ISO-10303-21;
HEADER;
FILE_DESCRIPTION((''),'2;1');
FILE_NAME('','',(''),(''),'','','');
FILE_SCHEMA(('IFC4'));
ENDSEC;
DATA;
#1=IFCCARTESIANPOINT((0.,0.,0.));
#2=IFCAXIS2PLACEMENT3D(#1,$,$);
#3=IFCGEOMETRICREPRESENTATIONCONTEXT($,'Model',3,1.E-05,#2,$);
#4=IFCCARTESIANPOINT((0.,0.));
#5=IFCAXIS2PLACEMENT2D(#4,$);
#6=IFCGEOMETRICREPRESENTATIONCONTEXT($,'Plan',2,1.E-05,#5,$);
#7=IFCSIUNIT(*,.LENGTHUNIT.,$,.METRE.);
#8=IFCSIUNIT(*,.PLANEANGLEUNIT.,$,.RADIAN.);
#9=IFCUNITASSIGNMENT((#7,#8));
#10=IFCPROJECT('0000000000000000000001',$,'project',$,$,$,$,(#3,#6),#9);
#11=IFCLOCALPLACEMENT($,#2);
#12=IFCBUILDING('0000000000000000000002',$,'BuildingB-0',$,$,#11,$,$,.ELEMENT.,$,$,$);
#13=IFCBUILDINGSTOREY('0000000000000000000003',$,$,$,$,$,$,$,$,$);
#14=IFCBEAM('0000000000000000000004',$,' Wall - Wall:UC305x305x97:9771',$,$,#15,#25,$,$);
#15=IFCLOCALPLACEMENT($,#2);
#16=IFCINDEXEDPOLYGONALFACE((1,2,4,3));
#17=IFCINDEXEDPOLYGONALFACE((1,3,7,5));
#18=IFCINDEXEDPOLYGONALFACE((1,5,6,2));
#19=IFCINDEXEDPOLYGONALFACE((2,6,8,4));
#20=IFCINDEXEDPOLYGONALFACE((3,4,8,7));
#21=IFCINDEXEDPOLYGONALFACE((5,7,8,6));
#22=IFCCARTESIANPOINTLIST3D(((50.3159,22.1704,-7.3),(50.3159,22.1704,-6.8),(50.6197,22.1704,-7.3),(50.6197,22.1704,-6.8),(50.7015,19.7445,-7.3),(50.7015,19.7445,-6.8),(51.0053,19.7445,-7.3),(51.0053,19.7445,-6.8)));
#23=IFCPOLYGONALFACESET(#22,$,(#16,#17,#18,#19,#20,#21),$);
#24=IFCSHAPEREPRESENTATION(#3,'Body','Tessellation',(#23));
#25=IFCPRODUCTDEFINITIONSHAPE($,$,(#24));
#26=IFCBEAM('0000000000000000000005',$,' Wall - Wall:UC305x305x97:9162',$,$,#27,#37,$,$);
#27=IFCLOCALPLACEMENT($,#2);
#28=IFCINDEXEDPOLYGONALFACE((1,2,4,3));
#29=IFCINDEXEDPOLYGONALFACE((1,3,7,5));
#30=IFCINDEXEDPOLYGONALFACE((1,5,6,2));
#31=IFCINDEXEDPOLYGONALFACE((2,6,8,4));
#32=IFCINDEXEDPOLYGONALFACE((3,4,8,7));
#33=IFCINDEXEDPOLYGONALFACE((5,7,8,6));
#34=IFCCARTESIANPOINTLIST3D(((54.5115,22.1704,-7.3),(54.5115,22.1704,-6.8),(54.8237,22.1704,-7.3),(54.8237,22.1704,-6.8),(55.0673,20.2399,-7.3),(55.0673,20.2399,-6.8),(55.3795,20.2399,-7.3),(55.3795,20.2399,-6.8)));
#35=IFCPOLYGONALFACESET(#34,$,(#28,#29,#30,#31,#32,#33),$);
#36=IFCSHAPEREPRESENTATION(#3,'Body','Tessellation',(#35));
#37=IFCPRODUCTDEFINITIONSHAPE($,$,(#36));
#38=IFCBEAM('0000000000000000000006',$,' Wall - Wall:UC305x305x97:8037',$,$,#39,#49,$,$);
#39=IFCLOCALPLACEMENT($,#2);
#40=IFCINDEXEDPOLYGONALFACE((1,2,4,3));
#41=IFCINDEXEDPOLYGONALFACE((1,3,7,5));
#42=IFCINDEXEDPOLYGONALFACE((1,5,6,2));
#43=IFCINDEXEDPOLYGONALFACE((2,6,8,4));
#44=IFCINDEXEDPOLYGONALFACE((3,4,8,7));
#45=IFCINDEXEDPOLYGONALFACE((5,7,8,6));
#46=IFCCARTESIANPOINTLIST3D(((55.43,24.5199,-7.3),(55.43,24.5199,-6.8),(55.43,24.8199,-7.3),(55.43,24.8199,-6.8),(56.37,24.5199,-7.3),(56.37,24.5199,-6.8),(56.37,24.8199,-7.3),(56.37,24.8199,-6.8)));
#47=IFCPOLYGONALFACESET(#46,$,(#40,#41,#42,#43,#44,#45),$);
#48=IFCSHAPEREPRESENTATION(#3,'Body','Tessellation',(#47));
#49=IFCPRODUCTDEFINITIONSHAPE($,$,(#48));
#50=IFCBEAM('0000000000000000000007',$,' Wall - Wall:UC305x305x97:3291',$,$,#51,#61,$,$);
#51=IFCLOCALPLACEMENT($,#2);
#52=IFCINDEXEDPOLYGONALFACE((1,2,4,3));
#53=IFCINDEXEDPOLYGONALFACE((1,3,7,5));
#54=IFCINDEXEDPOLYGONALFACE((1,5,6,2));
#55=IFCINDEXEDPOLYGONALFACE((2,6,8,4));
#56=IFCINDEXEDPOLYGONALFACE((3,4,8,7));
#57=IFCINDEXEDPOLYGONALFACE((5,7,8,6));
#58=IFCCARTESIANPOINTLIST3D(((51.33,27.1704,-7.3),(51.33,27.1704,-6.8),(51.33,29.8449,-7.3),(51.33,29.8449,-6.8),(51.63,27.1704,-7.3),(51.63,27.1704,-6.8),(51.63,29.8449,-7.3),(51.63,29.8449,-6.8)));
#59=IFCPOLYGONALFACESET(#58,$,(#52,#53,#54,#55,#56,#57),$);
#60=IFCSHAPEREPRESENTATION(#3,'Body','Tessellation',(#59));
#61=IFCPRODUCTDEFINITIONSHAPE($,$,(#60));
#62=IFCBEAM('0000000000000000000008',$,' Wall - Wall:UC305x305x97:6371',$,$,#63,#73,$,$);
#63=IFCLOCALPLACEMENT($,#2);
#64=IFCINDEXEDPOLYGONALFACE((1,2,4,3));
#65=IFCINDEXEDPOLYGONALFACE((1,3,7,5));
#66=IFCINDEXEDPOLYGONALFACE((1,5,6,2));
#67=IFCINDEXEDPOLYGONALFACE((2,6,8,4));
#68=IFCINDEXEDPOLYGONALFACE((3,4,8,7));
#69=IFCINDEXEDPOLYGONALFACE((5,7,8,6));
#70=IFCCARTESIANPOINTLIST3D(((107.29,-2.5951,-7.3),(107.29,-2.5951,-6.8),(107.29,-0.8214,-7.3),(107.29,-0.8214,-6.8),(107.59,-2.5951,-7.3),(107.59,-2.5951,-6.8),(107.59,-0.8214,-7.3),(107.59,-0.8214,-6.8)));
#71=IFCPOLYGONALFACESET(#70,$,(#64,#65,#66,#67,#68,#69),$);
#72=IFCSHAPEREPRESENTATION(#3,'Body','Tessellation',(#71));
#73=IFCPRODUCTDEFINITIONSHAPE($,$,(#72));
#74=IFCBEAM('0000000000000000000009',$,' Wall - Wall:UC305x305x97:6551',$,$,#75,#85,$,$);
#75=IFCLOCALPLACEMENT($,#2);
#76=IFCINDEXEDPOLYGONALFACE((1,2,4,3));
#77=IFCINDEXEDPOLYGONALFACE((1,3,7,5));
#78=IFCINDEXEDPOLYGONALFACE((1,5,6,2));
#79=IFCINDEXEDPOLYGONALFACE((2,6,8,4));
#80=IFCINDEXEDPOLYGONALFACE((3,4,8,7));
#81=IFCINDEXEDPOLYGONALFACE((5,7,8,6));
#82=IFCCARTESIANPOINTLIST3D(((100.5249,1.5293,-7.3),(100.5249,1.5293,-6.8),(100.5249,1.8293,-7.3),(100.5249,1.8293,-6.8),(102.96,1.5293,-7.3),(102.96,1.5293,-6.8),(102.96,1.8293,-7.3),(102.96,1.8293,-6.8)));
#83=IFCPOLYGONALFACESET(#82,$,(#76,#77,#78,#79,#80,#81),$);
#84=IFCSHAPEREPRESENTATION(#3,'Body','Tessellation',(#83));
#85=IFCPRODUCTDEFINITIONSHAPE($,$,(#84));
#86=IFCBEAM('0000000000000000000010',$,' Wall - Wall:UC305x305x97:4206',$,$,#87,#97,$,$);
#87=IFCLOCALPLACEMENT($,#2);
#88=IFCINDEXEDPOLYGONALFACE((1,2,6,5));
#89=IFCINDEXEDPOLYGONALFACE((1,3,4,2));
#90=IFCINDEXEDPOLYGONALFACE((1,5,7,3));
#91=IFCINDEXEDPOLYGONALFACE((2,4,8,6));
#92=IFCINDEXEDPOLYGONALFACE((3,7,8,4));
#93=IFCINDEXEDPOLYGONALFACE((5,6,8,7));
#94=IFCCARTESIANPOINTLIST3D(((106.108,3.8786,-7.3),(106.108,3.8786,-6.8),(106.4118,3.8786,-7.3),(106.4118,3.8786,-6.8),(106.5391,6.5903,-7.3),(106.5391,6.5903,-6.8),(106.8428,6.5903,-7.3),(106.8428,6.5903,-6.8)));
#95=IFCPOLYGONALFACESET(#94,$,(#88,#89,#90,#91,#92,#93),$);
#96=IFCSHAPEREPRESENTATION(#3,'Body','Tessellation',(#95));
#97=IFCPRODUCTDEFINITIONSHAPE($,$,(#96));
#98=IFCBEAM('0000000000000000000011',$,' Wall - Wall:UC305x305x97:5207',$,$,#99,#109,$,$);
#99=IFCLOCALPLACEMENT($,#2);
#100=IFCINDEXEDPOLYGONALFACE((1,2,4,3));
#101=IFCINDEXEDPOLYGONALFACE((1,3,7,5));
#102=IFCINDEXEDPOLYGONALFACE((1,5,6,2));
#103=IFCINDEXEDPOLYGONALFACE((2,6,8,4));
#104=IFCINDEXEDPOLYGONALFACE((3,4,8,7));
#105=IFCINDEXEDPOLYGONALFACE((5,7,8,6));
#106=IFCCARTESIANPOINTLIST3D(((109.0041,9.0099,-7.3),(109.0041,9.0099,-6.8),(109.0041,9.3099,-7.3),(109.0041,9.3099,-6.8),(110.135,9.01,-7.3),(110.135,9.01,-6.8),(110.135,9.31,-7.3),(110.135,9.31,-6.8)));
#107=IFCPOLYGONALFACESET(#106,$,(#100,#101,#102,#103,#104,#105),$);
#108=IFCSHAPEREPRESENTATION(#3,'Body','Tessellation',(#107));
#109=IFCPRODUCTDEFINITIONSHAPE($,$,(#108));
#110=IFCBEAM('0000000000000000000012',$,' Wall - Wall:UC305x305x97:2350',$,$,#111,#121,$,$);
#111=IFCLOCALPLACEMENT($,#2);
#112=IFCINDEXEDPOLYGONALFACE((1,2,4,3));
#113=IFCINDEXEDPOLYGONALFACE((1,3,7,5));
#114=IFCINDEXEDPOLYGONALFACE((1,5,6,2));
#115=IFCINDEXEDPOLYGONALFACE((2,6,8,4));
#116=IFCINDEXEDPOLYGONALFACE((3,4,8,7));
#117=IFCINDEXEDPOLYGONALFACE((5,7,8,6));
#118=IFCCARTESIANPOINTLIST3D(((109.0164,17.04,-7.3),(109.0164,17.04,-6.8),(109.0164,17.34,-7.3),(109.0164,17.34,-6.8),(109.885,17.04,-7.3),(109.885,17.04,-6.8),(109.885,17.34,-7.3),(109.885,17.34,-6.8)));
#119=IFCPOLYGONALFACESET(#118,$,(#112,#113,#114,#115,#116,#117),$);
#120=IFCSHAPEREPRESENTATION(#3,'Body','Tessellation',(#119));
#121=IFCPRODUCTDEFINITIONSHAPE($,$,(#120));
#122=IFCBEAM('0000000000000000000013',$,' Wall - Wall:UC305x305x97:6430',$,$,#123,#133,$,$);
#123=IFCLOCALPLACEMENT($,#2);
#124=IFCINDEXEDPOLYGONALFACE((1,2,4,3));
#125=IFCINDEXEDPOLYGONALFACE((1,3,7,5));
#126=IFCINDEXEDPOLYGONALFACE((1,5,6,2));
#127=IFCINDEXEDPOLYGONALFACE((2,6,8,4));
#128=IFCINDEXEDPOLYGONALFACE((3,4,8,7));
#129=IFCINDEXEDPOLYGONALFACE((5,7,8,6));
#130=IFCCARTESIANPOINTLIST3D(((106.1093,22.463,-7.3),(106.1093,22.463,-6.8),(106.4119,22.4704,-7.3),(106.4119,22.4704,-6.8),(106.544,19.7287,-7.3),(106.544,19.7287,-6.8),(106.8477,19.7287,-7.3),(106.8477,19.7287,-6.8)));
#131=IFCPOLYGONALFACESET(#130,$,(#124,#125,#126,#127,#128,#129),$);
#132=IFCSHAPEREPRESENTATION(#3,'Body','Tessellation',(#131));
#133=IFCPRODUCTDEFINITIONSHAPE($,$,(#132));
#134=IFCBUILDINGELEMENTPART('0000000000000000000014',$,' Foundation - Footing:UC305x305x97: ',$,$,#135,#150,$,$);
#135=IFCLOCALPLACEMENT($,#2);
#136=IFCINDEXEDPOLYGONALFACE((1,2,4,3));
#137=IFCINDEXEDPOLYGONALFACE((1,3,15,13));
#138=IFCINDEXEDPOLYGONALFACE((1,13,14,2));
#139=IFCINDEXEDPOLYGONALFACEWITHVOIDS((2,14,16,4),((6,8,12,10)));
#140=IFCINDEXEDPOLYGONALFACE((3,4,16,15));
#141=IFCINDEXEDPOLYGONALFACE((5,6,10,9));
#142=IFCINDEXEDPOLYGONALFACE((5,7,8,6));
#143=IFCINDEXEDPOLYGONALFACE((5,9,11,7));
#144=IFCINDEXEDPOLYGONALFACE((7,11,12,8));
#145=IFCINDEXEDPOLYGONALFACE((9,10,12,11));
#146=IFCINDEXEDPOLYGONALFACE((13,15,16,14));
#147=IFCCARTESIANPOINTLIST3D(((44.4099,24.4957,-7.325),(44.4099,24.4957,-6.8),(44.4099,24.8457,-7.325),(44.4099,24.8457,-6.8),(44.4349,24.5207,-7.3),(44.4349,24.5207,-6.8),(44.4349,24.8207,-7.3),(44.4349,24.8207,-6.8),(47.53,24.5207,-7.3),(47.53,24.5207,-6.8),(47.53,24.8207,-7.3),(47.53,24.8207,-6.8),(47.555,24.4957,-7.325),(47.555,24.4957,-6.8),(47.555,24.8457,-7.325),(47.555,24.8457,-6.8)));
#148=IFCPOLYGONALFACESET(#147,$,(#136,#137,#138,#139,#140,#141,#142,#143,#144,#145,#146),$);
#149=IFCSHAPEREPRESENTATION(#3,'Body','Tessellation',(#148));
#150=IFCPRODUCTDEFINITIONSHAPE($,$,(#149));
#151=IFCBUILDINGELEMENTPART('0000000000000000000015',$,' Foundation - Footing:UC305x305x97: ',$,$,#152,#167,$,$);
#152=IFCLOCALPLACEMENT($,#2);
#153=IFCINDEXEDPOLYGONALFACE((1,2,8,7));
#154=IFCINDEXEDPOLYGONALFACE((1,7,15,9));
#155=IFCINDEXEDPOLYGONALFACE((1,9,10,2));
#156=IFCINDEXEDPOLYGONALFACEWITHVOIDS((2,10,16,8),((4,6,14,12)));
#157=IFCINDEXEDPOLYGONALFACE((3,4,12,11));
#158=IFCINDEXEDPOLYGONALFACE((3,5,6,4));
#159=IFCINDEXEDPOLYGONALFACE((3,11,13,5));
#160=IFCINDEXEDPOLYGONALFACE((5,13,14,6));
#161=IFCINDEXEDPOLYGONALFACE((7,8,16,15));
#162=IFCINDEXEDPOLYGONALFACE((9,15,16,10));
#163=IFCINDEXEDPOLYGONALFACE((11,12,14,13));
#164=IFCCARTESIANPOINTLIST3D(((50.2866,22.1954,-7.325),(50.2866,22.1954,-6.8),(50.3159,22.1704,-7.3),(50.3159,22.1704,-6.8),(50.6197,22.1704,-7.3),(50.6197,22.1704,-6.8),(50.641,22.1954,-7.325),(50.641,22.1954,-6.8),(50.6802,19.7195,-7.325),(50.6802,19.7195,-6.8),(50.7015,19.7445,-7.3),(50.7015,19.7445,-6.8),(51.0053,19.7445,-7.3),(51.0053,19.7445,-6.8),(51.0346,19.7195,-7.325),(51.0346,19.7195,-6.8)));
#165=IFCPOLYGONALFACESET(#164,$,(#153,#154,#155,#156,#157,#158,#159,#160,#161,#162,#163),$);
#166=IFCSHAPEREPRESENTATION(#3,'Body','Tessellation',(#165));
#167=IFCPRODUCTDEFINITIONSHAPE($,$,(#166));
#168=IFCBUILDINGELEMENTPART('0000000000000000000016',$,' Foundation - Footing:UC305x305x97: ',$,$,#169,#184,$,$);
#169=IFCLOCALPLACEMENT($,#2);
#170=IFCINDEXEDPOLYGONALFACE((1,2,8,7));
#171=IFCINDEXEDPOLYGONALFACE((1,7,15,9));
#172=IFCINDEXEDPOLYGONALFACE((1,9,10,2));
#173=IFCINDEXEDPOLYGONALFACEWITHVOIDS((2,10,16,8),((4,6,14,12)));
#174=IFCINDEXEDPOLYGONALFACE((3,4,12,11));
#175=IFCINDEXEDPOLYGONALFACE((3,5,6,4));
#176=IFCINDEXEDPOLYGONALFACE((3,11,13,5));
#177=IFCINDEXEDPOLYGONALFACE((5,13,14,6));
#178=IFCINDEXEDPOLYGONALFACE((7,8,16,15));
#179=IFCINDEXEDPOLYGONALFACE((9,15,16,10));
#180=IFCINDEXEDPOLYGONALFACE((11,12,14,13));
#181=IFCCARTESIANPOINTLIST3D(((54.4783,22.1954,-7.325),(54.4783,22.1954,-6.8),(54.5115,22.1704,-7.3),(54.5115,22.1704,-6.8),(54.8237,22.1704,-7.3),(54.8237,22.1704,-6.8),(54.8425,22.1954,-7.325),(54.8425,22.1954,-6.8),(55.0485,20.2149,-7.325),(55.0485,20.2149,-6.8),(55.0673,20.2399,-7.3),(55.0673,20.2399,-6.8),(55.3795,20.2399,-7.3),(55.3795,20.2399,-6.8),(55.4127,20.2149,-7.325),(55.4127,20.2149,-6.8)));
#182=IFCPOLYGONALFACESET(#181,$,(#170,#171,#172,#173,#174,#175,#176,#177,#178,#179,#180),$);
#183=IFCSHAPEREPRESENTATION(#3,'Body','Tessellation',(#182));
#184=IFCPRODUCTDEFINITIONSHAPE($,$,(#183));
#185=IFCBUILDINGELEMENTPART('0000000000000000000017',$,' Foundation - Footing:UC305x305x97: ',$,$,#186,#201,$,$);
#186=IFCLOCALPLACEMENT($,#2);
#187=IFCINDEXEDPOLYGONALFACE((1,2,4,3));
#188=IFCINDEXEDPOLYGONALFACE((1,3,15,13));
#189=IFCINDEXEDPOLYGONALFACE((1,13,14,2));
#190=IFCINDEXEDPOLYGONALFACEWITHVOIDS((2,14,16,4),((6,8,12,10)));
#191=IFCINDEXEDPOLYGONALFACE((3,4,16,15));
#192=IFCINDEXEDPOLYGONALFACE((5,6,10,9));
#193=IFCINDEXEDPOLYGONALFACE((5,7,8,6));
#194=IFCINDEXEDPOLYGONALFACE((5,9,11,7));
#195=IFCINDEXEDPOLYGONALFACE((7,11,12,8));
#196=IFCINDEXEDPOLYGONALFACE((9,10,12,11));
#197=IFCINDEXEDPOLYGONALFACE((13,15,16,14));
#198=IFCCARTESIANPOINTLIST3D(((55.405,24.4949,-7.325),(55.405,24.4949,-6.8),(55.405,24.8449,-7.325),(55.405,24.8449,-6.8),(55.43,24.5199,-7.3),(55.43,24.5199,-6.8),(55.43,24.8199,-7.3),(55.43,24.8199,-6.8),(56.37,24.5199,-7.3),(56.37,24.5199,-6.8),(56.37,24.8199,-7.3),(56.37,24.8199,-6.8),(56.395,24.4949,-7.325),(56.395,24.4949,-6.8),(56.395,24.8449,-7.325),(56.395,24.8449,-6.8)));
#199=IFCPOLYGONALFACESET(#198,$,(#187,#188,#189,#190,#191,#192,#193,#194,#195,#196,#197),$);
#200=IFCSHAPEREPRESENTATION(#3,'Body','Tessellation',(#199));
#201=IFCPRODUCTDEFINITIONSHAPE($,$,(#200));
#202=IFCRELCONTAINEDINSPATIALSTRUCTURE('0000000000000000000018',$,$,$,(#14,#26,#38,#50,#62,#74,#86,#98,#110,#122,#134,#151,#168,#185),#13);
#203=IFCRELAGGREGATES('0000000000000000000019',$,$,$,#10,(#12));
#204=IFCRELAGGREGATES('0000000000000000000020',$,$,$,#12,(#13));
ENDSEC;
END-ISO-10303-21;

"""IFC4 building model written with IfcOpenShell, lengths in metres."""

from ifc_helpers import new_model, si_unit, origin, origin_2d, place, context, project, spatial, polyline, outline, extrude, element, save


model = new_model("IFC4")

# Units and contexts
model_context = context("Model", 3, precision=1e-05, world=origin())
plan_context = context("Plan", 2, precision=1e-05, world=origin_2d())
ifc_project = project(units=[si_unit("LENGTHUNIT", "METRE"), si_unit("PLANEANGLEUNIT", "RADIAN")], contexts=[model_context, plan_context])

# Building, storey
building_placement = place(None, origin())
building = spatial("IfcBuilding", under=ifc_project, at=building_placement, Name="BuildingB-0", CompositionType="ELEMENT")
storey = spatial("IfcBuildingStorey", under=building)

# Beams
element("IfcBeam", 1, inside=storey, Name=" Wall - Wall:UC305x305x97:9771", context=model_context, shape_type="SweptSolid", body=[
    extrude(outline(polyline([(50.7015, 19.7445, -7.3), (51.0053, 19.7445, -7.3), (50.6197, 22.1704, -7.3), (50.3159, 22.1704, -7.3), (50.7015, 19.7445, -7.3)])), None, (0.0, 0.0, 1.0), 0.5),
])
element("IfcBeam", 2, inside=storey, Name=" Wall - Wall:UC305x305x97:9162", context=model_context, shape_type="SweptSolid", body=[
    extrude(outline(polyline([(55.0673, 20.2399, -7.3), (55.3795, 20.2399, -7.3), (54.8237, 22.1704, -7.3), (54.5115, 22.1704, -7.3), (55.0673, 20.2399, -7.3)])), None, (0.0, 0.0, 1.0), 0.5),
])
element("IfcBeam", 3, inside=storey, Name=" Wall - Wall:UC305x305x97:8037", context=model_context, shape_type="SweptSolid", body=[
    extrude(outline(polyline([(55.43, 24.5199, -7.3), (55.43, 24.8199, -7.3), (56.37, 24.8199, -7.3), (56.37, 24.5199, -7.3), (55.43, 24.5199, -7.3)])), None, (0.0, 0.0, 1.0), 0.5),
])
element("IfcBeam", 4, inside=storey, Name=" Wall - Wall:UC305x305x97:3291", context=model_context, shape_type="SweptSolid", body=[
    extrude(outline(polyline([(51.33, 27.1704, -7.3), (51.63, 27.1704, -7.3), (51.63, 29.8449, -7.3), (51.33, 29.8449, -7.3), (51.33, 27.1704, -7.3)])), None, (0.0, 0.0, 1.0), 0.5),
])
element("IfcBeam", 5, inside=storey, Name=" Wall - Wall:UC305x305x97:6371", context=model_context, shape_type="SweptSolid", body=[
    extrude(outline(polyline([(107.59, -2.5951, -7.3), (107.29, -2.5951, -7.3), (107.29, -0.8214, -7.3), (107.59, -0.8214, -7.3), (107.59, -2.5951, -7.3)])), None, (0.0, 0.0, 1.0), 0.5),
])
element("IfcBeam", 6, inside=storey, Name=" Wall - Wall:UC305x305x97:6551", context=model_context, shape_type="SweptSolid", body=[
    extrude(outline(polyline([(102.96, 1.5293, -7.3), (102.96, 1.8293, -7.3), (100.5249, 1.8293, -7.3), (100.5249, 1.5293, -7.3), (102.96, 1.5293, -7.3)])), None, (0.0, 0.0, 1.0), 0.5),
])
element("IfcBeam", 7, inside=storey, Name=" Wall - Wall:UC305x305x97:4206", context=model_context, shape_type="SweptSolid", body=[
    extrude(outline(polyline([(106.4118, 3.8786, -7.3), (106.8428, 6.5903, -7.3), (106.5391, 6.5903, -7.3), (106.108, 3.8786, -7.3), (106.4118, 3.8786, -7.3)])), None, (0.0, 0.0, 1.0), 0.5),
])
element("IfcBeam", 8, inside=storey, Name=" Wall - Wall:UC305x305x97:5207", context=model_context, shape_type="SweptSolid", body=[
    extrude(outline(polyline([(110.135, 9.01, -7.3), (110.135, 9.31, -7.3), (109.0041, 9.3099, -7.3), (109.0041, 9.0099, -7.3), (110.135, 9.01, -7.3)])), None, (0.0, 0.0, 1.0), 0.5),
])
element("IfcBeam", 9, inside=storey, Name=" Wall - Wall:UC305x305x97:2350", context=model_context, shape_type="SweptSolid", body=[
    extrude(outline(polyline([(109.885, 17.04, -7.3), (109.885, 17.34, -7.3), (109.0164, 17.34, -7.3), (109.0164, 17.04, -7.3), (109.885, 17.04, -7.3)])), None, (0.0, 0.0, 1.0), 0.5),
])
element("IfcBeam", 10, inside=storey, Name=" Wall - Wall:UC305x305x97:6430", context=model_context, shape_type="SweptSolid", body=[
    extrude(outline(polyline([(106.544, 19.7287, -7.3), (106.8477, 19.7287, -7.3), (106.4119, 22.4704, -7.3), (106.1093, 22.463, -7.3), (106.544, 19.7287, -7.3)])), None, (0.0, 0.0, 1.0), 0.5),
])

# Building element parts, openings
building_element_part_1 = element("IfcBuildingElementPart", 11, inside=storey, Name=" Foundation - Footing:UC305x305x97: ", context=model_context, shape_type="SweptSolid", body=[
    extrude(outline(polyline([(44.4099, 24.4957, -7.325), (44.4099, 24.8457, -7.325), (47.555, 24.8457, -7.325), (47.555, 24.4957, -7.325), (44.4099, 24.4957, -7.325)])), None, (0.0, 0.0, 1.0), 0.525),
])
element("IfcOpeningElement", 12, inside=storey, cuts=building_element_part_1, context=model_context, shape_type="SweptSolid", body=[
    extrude(outline(polyline([(44.4349, 24.5207, -7.3), (44.4349, 24.8207, -7.3), (47.53, 24.8207, -7.3), (47.53, 24.5207, -7.3), (44.4349, 24.5207, -7.3)])), None, (0.0, 0.0, 1.0), 0.5),
])
building_element_part_2 = element("IfcBuildingElementPart", 13, inside=storey, Name=" Foundation - Footing:UC305x305x97: ", context=model_context, shape_type="SweptSolid", body=[
    extrude(outline(polyline([(50.6802, 19.7195, -7.325), (51.0346, 19.7195, -7.325), (50.641, 22.1954, -7.325), (50.2866, 22.1954, -7.325), (50.6802, 19.7195, -7.325)])), None, (0.0, 0.0, 1.0), 0.525),
])
element("IfcOpeningElement", 14, inside=storey, cuts=building_element_part_2, context=model_context, shape_type="SweptSolid", body=[
    extrude(outline(polyline([(50.7015, 19.7445, -7.3), (51.0053, 19.7445, -7.3), (50.6197, 22.1704, -7.3), (50.3159, 22.1704, -7.3), (50.7015, 19.7445, -7.3)])), None, (0.0, 0.0, 1.0), 0.5),
])
building_element_part_3 = element("IfcBuildingElementPart", 15, inside=storey, Name=" Foundation - Footing:UC305x305x97: ", context=model_context, shape_type="SweptSolid", body=[
    extrude(outline(polyline([(55.0485, 20.2149, -7.325), (55.4127, 20.2149, -7.325), (54.8425, 22.1954, -7.325), (54.4783, 22.1954, -7.325), (55.0485, 20.2149, -7.325)])), None, (0.0, 0.0, 1.0), 0.525),
])
element("IfcOpeningElement", 16, inside=storey, cuts=building_element_part_3, context=model_context, shape_type="SweptSolid", body=[
    extrude(outline(polyline([(55.0673, 20.2399, -7.3), (55.3795, 20.2399, -7.3), (54.8237, 22.1704, -7.3), (54.5115, 22.1704, -7.3), (55.0673, 20.2399, -7.3)])), None, (0.0, 0.0, 1.0), 0.5),
])
building_element_part_4 = element("IfcBuildingElementPart", 17, inside=storey, Name=" Foundation - Footing:UC305x305x97: ", context=model_context, shape_type="SweptSolid", body=[
    extrude(outline(polyline([(55.405, 24.4949, -7.325), (55.405, 24.8449, -7.325), (56.395, 24.8449, -7.325), (56.395, 24.4949, -7.325), (55.405, 24.4949, -7.325)])), None, (0.0, 0.0, 1.0), 0.525),
])
element("IfcOpeningElement", 18, inside=storey, cuts=building_element_part_4, context=model_context, shape_type="SweptSolid", body=[
    extrude(outline(polyline([(55.43, 24.5199, -7.3), (55.43, 24.8199, -7.3), (56.37, 24.8199, -7.3), (56.37, 24.5199, -7.3), (55.43, 24.5199, -7.3)])), None, (0.0, 0.0, 1.0), 0.5),
])

save(model, "model.ifc")
